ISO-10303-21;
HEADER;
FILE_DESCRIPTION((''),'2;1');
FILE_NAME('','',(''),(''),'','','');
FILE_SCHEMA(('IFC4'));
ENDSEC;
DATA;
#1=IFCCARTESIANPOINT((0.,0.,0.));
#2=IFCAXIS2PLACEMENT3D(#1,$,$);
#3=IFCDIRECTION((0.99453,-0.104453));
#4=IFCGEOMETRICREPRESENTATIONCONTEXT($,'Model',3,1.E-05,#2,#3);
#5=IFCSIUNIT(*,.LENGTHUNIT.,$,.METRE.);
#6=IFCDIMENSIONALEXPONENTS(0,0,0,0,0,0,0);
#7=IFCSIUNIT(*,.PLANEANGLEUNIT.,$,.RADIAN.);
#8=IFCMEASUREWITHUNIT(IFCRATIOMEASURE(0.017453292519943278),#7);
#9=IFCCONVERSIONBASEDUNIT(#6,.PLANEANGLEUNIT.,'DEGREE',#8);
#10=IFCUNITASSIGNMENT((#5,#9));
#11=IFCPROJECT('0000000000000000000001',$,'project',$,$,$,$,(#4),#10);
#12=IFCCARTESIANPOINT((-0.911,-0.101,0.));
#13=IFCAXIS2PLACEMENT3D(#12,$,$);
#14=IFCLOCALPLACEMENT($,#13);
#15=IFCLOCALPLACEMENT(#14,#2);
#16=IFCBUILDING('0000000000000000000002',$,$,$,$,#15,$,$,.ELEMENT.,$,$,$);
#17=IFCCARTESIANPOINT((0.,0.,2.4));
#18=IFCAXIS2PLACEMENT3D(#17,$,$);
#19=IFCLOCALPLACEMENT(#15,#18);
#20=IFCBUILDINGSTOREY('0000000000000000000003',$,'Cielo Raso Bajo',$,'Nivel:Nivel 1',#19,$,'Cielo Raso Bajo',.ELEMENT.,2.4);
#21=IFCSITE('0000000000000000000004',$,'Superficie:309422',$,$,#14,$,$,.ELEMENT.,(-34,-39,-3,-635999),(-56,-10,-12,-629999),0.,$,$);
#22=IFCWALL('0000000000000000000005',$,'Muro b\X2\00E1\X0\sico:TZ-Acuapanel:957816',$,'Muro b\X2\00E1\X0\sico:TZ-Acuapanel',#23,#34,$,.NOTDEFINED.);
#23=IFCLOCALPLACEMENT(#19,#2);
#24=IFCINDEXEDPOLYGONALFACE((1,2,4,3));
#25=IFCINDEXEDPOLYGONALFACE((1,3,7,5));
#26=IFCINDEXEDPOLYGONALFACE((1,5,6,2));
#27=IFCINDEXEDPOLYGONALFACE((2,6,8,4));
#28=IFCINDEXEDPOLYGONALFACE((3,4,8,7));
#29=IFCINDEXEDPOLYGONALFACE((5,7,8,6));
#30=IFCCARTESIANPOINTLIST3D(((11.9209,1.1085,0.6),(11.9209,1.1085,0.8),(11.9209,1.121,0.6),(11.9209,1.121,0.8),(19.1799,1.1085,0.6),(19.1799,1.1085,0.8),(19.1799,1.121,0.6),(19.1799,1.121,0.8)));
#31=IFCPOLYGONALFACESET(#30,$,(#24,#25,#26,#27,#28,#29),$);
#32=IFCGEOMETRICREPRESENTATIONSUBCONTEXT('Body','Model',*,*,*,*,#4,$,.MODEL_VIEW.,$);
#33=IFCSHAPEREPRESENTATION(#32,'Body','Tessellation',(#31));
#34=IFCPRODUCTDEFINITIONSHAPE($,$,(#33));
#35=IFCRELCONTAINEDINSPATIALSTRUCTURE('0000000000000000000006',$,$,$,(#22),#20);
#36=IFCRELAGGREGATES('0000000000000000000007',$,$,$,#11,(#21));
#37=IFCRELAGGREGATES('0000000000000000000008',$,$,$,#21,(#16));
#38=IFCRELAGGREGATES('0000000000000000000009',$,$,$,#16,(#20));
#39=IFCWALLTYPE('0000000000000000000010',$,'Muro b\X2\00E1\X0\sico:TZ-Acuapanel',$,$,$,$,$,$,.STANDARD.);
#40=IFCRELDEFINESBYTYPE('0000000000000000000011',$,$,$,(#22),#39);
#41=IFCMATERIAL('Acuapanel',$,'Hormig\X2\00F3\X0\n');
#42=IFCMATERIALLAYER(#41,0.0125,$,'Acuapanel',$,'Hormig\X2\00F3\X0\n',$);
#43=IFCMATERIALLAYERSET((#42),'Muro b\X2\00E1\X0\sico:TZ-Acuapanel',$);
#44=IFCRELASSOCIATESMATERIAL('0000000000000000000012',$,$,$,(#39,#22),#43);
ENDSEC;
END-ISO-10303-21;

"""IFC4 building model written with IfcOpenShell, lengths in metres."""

from ifc_helpers import new_model, entity, si_unit, converted_unit, direction, frame, frame_2d, origin, place, context, subcontext, project, spatial, polyline, rectangle, extrude, clip, bounded_halfspace, material, layer, layer_set, layer_usage, type_object, element, save


model = new_model("IFC4")

# Units and contexts
model_context = context("Model", 3, precision=1e-05, world=origin(), true_north=direction((0.99453, -0.104453)))
body_context = subcontext(model_context, "Body", "Model", "MODEL_VIEW")
ifc_project = project(units=[si_unit("LENGTHUNIT", "METRE"), converted_unit("PLANEANGLEUNIT", "DEGREE", entity("IfcRatioMeasure", 0.017453292519943278), si_unit("PLANEANGLEUNIT", "RADIAN"), dimensions=[0, 0, 0, 0, 0, 0, 0])], contexts=[model_context])

# Site, building, storey
site_placement = place(None, frame((-0.911, -0.101, 0.0)))
site = spatial("IfcSite", under=ifc_project, at=site_placement, Name="Superficie:309422", CompositionType="ELEMENT", RefLatitude=(-34, -39, -3, -635999), RefLongitude=(-56, -10, -12, -629999), RefElevation=0.0)
building_placement = place(site_placement, origin())
building = spatial("IfcBuilding", under=site, at=building_placement, CompositionType="ELEMENT")
storey_placement = place(building_placement, frame((0.0, 0.0, 2.4)))
storey = spatial("IfcBuildingStorey", under=building, at=storey_placement, Name="Cielo Raso Bajo", ObjectType="Nivel:Nivel 1", LongName="Cielo Raso Bajo", CompositionType="ELEMENT", Elevation=2.4)

# Shared definitions
ifc_material_1 = material(Name="Acuapanel", Category="Hormigón")

# Wall
ifc_layer_1 = layer(ifc_material_1, 0.0125, Name="Acuapanel", Category="Hormigón")
ifc_layer_set_1 = layer_set([ifc_layer_1], Name="Muro básico:TZ-Acuapanel")
wall_type_1 = type_object("IfcWallType", Name="Muro básico:TZ-Acuapanel", PredefinedType="STANDARD", material=ifc_layer_set_1)
ifc_layer_usage_1 = layer_usage(ifc_layer_set_1, "AXIS2", "POSITIVE", -0.0063)
wall_1_placement = place(storey_placement, frame((11.9209, 1.1148, 0.6)))
element("IfcWall", 1, at=wall_1_placement, inside=storey, type_object=wall_type_1, material=ifc_layer_usage_1, Name="Muro básico:TZ-Acuapanel:957816", ObjectType="Muro básico:TZ-Acuapanel", PredefinedType="NOTDEFINED", context=body_context, shape_type="Clipping", body=[
    clip(extrude(rectangle(XDim=7.259, YDim=0.0125, at=frame_2d((3.6295, 0.0), x_axis=(-1.0, 0.0))), origin(), (0.0, 0.0, 1.0), 0.2), bounded_halfspace(frame((0.0, -0.0062, 0.2)), False, frame((0.0, -0.0062, 0.2)), polyline([(0.0, 0.0), (2.2125, 0.0), (2.2125, 0.0038), (0.0, 0.0038), (0.0, 0.0)]))),
])

save(model, "model.ifc")
